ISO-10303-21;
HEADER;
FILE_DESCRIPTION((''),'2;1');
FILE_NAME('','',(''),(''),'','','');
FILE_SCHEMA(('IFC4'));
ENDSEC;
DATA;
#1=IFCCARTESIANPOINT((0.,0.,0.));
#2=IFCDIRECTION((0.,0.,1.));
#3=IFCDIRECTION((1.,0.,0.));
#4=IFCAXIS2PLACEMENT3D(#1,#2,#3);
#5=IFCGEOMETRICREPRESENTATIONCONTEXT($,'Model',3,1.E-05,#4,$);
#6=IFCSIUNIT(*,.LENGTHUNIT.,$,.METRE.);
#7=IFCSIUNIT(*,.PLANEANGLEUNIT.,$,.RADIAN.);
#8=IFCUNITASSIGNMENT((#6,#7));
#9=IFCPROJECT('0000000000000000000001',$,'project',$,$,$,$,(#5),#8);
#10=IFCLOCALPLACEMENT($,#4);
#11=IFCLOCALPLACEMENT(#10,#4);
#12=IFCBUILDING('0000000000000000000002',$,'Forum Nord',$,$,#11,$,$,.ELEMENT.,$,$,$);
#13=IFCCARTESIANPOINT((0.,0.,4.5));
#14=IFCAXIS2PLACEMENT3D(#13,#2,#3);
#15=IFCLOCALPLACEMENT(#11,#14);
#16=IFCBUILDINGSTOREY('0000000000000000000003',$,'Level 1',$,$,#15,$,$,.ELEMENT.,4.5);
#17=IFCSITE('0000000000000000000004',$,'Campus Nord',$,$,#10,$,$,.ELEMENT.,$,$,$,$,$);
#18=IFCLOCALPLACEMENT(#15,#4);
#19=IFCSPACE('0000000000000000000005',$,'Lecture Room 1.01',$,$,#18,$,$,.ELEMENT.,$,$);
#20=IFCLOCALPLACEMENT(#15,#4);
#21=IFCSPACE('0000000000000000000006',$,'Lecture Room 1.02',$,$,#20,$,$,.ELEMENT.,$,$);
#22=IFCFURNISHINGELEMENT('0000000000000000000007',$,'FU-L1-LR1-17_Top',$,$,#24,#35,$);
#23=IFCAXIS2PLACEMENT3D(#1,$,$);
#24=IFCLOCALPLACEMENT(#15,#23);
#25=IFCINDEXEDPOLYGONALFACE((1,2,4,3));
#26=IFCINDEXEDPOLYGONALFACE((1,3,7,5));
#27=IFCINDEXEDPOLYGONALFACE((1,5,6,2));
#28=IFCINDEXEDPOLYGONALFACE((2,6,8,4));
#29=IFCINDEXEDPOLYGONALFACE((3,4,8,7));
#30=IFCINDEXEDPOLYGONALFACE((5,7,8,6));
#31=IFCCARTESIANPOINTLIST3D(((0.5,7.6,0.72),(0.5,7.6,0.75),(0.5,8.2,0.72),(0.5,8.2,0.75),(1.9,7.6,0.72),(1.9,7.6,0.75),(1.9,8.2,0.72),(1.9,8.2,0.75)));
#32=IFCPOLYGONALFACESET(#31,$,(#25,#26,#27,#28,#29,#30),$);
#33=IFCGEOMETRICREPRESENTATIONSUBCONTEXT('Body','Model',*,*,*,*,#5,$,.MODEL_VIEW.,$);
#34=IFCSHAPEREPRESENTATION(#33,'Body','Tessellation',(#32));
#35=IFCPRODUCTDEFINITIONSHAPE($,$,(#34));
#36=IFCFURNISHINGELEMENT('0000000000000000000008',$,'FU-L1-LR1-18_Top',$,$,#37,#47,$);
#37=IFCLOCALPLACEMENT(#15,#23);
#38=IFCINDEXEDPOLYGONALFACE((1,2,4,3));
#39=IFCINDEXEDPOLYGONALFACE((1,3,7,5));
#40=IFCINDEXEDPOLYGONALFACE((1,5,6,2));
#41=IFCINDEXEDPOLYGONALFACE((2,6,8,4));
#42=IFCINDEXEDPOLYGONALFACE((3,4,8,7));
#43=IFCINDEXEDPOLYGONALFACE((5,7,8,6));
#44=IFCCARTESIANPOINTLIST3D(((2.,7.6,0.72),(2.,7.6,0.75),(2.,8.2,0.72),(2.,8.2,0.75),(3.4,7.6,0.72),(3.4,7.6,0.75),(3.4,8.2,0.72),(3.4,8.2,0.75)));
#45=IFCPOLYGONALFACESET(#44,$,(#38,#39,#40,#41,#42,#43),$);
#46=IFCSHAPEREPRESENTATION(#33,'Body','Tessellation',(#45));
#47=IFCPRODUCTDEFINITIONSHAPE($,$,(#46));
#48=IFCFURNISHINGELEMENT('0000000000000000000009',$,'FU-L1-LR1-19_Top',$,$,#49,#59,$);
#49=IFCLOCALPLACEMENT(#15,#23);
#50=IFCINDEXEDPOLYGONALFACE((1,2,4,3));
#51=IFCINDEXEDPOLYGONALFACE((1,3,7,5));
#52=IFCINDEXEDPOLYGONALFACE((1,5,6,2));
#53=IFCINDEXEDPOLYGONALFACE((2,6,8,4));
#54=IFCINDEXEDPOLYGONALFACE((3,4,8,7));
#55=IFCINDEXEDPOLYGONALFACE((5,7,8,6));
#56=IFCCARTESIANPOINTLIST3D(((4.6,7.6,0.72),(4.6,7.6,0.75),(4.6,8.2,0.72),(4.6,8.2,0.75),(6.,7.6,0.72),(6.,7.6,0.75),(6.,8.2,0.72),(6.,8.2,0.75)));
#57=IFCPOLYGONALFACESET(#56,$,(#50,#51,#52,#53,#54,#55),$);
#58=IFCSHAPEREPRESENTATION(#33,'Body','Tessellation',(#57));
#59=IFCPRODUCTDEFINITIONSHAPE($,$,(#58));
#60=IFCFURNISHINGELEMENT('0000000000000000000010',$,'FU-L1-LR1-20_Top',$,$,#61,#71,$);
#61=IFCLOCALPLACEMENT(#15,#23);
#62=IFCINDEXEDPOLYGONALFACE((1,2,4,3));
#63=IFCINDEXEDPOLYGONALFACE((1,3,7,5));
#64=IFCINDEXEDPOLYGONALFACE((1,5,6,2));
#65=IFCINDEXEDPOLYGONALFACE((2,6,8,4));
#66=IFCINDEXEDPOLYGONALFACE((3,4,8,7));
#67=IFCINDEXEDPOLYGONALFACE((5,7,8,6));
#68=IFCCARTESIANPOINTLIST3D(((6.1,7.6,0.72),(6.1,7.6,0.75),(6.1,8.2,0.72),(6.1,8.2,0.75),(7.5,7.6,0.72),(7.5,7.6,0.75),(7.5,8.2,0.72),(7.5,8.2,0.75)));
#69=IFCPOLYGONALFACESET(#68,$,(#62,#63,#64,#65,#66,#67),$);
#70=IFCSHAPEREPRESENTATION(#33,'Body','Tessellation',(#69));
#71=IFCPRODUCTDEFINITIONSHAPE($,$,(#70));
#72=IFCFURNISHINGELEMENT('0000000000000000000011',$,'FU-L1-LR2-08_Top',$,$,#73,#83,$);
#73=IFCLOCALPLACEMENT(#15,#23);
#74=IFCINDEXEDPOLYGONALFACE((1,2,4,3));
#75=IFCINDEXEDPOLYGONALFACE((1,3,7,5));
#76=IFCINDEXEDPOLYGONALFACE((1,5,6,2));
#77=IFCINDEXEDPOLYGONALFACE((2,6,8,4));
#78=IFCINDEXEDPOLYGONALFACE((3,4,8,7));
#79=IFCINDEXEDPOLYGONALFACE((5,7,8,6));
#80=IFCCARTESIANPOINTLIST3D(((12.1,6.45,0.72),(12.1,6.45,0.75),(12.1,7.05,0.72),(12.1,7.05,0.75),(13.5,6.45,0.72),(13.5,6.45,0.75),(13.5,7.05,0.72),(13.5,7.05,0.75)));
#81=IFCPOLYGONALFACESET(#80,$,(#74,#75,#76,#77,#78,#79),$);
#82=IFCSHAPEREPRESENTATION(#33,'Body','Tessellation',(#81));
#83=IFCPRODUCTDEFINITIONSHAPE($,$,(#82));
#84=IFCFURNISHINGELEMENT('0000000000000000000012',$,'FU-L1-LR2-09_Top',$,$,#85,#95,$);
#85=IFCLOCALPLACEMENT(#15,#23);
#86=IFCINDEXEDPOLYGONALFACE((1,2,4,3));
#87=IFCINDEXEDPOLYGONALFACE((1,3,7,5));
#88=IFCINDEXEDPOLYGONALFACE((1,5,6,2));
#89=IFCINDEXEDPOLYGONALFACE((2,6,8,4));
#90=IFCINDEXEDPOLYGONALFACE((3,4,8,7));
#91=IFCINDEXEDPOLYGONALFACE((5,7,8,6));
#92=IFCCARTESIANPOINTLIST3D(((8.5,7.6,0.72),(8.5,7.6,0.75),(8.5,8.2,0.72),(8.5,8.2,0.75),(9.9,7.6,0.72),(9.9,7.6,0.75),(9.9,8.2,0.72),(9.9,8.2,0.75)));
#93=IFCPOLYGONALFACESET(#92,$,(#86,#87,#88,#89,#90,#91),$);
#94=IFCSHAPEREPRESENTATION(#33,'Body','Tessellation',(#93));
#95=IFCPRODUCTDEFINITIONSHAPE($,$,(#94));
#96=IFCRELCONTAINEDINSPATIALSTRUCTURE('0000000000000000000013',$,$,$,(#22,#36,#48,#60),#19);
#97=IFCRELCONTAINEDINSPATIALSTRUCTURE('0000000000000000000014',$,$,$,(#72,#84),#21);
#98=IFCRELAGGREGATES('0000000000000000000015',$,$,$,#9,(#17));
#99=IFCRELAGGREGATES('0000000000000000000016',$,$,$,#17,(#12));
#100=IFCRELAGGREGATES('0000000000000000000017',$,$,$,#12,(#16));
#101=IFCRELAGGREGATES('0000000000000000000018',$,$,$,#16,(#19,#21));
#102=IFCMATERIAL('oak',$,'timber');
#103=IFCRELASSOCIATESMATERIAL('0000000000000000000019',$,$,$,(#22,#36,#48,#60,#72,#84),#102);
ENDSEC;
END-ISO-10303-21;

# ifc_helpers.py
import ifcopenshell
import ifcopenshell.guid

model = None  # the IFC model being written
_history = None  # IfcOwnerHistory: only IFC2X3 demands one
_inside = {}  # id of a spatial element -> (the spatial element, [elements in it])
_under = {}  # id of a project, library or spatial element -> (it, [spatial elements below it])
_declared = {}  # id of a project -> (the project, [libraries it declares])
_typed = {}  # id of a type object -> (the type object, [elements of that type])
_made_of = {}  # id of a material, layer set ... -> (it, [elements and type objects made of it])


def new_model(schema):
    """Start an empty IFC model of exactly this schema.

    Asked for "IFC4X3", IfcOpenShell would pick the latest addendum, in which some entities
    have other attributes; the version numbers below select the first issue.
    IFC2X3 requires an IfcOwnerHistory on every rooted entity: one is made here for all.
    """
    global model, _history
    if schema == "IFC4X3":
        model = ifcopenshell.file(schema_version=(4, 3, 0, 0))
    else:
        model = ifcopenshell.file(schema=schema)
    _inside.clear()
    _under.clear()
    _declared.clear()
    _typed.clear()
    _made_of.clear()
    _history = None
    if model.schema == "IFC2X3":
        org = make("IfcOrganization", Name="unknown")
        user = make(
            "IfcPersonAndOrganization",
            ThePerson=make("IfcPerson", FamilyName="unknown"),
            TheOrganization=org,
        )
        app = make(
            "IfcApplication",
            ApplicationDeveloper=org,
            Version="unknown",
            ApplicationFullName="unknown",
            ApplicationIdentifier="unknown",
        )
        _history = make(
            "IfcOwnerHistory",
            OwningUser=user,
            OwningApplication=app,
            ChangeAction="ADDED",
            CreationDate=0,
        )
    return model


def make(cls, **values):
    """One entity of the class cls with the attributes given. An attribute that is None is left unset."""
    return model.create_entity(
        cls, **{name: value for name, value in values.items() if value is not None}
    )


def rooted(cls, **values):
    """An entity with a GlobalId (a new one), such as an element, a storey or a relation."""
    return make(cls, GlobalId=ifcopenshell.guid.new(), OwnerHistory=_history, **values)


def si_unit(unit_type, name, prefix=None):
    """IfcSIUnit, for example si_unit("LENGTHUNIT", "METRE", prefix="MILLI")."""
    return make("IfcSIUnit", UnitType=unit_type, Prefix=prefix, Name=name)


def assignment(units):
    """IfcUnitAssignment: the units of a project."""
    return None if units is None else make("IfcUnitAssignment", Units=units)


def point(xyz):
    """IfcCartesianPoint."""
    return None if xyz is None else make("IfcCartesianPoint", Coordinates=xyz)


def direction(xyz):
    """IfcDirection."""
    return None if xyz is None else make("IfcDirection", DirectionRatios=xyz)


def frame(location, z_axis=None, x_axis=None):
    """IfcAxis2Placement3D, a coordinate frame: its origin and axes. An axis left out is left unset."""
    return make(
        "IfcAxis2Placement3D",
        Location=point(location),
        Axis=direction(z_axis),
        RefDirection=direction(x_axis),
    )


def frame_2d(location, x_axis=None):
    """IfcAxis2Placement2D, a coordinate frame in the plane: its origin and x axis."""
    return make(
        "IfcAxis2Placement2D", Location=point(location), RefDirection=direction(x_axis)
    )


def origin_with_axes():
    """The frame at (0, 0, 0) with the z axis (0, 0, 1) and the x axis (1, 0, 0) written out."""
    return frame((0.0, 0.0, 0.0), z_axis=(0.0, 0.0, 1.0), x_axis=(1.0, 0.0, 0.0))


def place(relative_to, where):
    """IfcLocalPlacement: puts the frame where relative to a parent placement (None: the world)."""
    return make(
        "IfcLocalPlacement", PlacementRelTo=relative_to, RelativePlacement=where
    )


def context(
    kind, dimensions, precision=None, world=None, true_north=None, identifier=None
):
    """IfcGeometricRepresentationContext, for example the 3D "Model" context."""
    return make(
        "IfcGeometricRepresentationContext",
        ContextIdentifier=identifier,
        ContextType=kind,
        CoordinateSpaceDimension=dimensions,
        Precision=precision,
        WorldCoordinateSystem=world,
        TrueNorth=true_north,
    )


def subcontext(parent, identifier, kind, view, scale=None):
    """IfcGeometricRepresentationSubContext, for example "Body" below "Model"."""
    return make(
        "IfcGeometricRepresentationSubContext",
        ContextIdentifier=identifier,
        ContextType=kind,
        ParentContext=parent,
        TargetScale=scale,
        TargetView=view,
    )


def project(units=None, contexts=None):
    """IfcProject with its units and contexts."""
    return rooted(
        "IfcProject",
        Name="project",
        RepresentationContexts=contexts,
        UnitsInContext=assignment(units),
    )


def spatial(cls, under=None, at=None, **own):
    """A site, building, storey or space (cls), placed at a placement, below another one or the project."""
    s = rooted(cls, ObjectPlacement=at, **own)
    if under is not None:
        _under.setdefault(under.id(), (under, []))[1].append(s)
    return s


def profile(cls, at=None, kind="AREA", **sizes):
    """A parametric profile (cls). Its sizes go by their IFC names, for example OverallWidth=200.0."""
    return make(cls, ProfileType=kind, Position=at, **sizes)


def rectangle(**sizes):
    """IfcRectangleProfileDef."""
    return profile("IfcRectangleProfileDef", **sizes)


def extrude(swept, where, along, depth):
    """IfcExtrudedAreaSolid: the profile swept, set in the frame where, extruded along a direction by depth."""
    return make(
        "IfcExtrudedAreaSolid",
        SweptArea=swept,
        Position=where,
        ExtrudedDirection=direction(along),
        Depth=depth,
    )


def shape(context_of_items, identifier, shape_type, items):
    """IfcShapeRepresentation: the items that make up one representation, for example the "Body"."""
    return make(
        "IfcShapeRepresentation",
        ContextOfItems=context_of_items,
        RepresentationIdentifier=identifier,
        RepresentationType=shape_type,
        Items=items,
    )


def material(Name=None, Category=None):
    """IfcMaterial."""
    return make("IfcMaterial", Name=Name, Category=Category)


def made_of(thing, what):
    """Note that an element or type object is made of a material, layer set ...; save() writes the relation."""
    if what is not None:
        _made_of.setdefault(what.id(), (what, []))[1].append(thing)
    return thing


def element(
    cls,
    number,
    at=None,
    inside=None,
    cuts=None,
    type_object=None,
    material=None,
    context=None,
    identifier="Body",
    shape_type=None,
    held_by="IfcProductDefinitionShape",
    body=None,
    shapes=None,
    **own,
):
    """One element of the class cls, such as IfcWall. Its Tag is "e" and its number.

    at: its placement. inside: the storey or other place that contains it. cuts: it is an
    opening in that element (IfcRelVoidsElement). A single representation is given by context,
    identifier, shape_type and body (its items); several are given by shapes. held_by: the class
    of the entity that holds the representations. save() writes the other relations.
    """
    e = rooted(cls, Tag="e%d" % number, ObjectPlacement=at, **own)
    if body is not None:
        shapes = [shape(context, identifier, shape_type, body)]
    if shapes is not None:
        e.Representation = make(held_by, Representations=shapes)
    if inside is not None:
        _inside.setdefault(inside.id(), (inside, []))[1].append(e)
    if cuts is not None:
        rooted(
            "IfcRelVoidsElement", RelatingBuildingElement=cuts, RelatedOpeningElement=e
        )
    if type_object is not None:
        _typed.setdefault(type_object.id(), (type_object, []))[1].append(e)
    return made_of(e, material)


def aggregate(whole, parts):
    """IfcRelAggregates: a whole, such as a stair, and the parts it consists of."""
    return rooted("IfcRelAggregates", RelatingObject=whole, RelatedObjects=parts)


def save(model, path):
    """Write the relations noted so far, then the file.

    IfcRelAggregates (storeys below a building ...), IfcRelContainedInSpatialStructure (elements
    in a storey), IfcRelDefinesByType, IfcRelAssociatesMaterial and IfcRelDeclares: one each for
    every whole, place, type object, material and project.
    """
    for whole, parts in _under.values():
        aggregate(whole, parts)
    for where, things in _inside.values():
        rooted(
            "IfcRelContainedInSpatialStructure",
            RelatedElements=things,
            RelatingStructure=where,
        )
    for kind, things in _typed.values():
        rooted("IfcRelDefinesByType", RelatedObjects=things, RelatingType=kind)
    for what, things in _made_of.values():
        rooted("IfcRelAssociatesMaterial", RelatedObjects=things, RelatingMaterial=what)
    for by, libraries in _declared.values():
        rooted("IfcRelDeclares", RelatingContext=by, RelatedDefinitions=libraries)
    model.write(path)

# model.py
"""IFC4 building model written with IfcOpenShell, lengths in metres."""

from ifc_helpers import new_model, si_unit, frame, frame_2d, origin_with_axes, place, context, subcontext, project, spatial, rectangle, extrude, material, element, save


model = new_model("IFC4")

# Units and contexts
model_context = context("Model", 3, precision=1e-05, world=origin_with_axes())
body_context = subcontext(model_context, "Body", "Model", "MODEL_VIEW")
ifc_project = project(units=[si_unit("LENGTHUNIT", "METRE"), si_unit("PLANEANGLEUNIT", "RADIAN")], contexts=[model_context])

# Site, building, storey, space
site_placement = place(None, origin_with_axes())
site = spatial("IfcSite", under=ifc_project, at=site_placement, Name="Campus Nord", CompositionType="ELEMENT")
building_placement = place(site_placement, origin_with_axes())
building = spatial("IfcBuilding", under=site, at=building_placement, Name="Forum Nord", CompositionType="ELEMENT")
storey_placement = place(building_placement, frame((0.0, 0.0, 4.5), z_axis=(0.0, 0.0, 1.0), x_axis=(1.0, 0.0, 0.0)))
storey = spatial("IfcBuildingStorey", under=building, at=storey_placement, Name="Level 1", CompositionType="ELEMENT", Elevation=4.5)
space_1_placement = place(storey_placement, origin_with_axes())
space_1 = spatial("IfcSpace", under=storey, at=space_1_placement, Name="Lecture Room 1.01", CompositionType="ELEMENT")

# Furnishing elements
ifc_material_1 = material(Name="oak", Category="timber")
furnishing_1_placement = place(storey_placement, frame((0.5, 7.6, 0.0), z_axis=(0.0, 0.0, 1.0), x_axis=(1.0, 0.0, 0.0)))
element("IfcFurnishingElement", 1, at=furnishing_1_placement, inside=space_1, material=ifc_material_1, Name="FU-L1-LR1-17_Top", context=body_context, shape_type="SweptSolid", body=[
    extrude(rectangle(XDim=1.4, YDim=0.6, at=frame_2d((0.7, 0.3), x_axis=(1.0, 0.0))), frame((0.0, 0.0, 0.72), z_axis=(0.0, 0.0, 1.0), x_axis=(1.0, 0.0, 0.0)), (0.0, 0.0, 1.0), 0.03),
])
furnishing_2_placement = place(storey_placement, frame((2.0, 7.6, 0.0), z_axis=(0.0, 0.0, 1.0), x_axis=(1.0, 0.0, 0.0)))
element("IfcFurnishingElement", 2, at=furnishing_2_placement, inside=space_1, material=ifc_material_1, Name="FU-L1-LR1-18_Top", context=body_context, shape_type="SweptSolid", body=[
    extrude(rectangle(XDim=1.4, YDim=0.6, at=frame_2d((0.7, 0.3), x_axis=(1.0, 0.0))), frame((0.0, 0.0, 0.72), z_axis=(0.0, 0.0, 1.0), x_axis=(1.0, 0.0, 0.0)), (0.0, 0.0, 1.0), 0.03),
])
furnishing_3_placement = place(storey_placement, frame((4.6, 7.6, 0.0), z_axis=(0.0, 0.0, 1.0), x_axis=(1.0, 0.0, 0.0)))
element("IfcFurnishingElement", 3, at=furnishing_3_placement, inside=space_1, material=ifc_material_1, Name="FU-L1-LR1-19_Top", context=body_context, shape_type="SweptSolid", body=[
    extrude(rectangle(XDim=1.4, YDim=0.6, at=frame_2d((0.7, 0.3), x_axis=(1.0, 0.0))), frame((0.0, 0.0, 0.72), z_axis=(0.0, 0.0, 1.0), x_axis=(1.0, 0.0, 0.0)), (0.0, 0.0, 1.0), 0.03),
])
furnishing_4_placement = place(storey_placement, frame((6.1, 7.6, 0.0), z_axis=(0.0, 0.0, 1.0), x_axis=(1.0, 0.0, 0.0)))
element("IfcFurnishingElement", 4, at=furnishing_4_placement, inside=space_1, material=ifc_material_1, Name="FU-L1-LR1-20_Top", context=body_context, shape_type="SweptSolid", body=[
    extrude(rectangle(XDim=1.4, YDim=0.6, at=frame_2d((0.7, 0.3), x_axis=(1.0, 0.0))), frame((0.0, 0.0, 0.72), z_axis=(0.0, 0.0, 1.0), x_axis=(1.0, 0.0, 0.0)), (0.0, 0.0, 1.0), 0.03),
])

# Shared definitions
space_2_placement = place(storey_placement, origin_with_axes())
space_2 = spatial("IfcSpace", under=storey, at=space_2_placement, Name="Lecture Room 1.02", CompositionType="ELEMENT")

# Furnishing elements
furnishing_5_placement = place(storey_placement, frame((12.1, 6.45, 0.0), z_axis=(0.0, 0.0, 1.0), x_axis=(1.0, 0.0, 0.0)))
element("IfcFurnishingElement", 5, at=furnishing_5_placement, inside=space_2, material=ifc_material_1, Name="FU-L1-LR2-08_Top", context=body_context, shape_type="SweptSolid", body=[
    extrude(rectangle(XDim=1.4, YDim=0.6, at=frame_2d((0.7, 0.3), x_axis=(1.0, 0.0))), frame((0.0, 0.0, 0.72), z_axis=(0.0, 0.0, 1.0), x_axis=(1.0, 0.0, 0.0)), (0.0, 0.0, 1.0), 0.03),
])
furnishing_6_placement = place(storey_placement, frame((8.5, 7.6, 0.0), z_axis=(0.0, 0.0, 1.0), x_axis=(1.0, 0.0, 0.0)))
element("IfcFurnishingElement", 6, at=furnishing_6_placement, inside=space_2, material=ifc_material_1, Name="FU-L1-LR2-09_Top", context=body_context, shape_type="SweptSolid", body=[
    extrude(rectangle(XDim=1.4, YDim=0.6, at=frame_2d((0.7, 0.3), x_axis=(1.0, 0.0))), frame((0.0, 0.0, 0.72), z_axis=(0.0, 0.0, 1.0), x_axis=(1.0, 0.0, 0.0)), (0.0, 0.0, 1.0), 0.03),
])

save(model, "model.ifc")
